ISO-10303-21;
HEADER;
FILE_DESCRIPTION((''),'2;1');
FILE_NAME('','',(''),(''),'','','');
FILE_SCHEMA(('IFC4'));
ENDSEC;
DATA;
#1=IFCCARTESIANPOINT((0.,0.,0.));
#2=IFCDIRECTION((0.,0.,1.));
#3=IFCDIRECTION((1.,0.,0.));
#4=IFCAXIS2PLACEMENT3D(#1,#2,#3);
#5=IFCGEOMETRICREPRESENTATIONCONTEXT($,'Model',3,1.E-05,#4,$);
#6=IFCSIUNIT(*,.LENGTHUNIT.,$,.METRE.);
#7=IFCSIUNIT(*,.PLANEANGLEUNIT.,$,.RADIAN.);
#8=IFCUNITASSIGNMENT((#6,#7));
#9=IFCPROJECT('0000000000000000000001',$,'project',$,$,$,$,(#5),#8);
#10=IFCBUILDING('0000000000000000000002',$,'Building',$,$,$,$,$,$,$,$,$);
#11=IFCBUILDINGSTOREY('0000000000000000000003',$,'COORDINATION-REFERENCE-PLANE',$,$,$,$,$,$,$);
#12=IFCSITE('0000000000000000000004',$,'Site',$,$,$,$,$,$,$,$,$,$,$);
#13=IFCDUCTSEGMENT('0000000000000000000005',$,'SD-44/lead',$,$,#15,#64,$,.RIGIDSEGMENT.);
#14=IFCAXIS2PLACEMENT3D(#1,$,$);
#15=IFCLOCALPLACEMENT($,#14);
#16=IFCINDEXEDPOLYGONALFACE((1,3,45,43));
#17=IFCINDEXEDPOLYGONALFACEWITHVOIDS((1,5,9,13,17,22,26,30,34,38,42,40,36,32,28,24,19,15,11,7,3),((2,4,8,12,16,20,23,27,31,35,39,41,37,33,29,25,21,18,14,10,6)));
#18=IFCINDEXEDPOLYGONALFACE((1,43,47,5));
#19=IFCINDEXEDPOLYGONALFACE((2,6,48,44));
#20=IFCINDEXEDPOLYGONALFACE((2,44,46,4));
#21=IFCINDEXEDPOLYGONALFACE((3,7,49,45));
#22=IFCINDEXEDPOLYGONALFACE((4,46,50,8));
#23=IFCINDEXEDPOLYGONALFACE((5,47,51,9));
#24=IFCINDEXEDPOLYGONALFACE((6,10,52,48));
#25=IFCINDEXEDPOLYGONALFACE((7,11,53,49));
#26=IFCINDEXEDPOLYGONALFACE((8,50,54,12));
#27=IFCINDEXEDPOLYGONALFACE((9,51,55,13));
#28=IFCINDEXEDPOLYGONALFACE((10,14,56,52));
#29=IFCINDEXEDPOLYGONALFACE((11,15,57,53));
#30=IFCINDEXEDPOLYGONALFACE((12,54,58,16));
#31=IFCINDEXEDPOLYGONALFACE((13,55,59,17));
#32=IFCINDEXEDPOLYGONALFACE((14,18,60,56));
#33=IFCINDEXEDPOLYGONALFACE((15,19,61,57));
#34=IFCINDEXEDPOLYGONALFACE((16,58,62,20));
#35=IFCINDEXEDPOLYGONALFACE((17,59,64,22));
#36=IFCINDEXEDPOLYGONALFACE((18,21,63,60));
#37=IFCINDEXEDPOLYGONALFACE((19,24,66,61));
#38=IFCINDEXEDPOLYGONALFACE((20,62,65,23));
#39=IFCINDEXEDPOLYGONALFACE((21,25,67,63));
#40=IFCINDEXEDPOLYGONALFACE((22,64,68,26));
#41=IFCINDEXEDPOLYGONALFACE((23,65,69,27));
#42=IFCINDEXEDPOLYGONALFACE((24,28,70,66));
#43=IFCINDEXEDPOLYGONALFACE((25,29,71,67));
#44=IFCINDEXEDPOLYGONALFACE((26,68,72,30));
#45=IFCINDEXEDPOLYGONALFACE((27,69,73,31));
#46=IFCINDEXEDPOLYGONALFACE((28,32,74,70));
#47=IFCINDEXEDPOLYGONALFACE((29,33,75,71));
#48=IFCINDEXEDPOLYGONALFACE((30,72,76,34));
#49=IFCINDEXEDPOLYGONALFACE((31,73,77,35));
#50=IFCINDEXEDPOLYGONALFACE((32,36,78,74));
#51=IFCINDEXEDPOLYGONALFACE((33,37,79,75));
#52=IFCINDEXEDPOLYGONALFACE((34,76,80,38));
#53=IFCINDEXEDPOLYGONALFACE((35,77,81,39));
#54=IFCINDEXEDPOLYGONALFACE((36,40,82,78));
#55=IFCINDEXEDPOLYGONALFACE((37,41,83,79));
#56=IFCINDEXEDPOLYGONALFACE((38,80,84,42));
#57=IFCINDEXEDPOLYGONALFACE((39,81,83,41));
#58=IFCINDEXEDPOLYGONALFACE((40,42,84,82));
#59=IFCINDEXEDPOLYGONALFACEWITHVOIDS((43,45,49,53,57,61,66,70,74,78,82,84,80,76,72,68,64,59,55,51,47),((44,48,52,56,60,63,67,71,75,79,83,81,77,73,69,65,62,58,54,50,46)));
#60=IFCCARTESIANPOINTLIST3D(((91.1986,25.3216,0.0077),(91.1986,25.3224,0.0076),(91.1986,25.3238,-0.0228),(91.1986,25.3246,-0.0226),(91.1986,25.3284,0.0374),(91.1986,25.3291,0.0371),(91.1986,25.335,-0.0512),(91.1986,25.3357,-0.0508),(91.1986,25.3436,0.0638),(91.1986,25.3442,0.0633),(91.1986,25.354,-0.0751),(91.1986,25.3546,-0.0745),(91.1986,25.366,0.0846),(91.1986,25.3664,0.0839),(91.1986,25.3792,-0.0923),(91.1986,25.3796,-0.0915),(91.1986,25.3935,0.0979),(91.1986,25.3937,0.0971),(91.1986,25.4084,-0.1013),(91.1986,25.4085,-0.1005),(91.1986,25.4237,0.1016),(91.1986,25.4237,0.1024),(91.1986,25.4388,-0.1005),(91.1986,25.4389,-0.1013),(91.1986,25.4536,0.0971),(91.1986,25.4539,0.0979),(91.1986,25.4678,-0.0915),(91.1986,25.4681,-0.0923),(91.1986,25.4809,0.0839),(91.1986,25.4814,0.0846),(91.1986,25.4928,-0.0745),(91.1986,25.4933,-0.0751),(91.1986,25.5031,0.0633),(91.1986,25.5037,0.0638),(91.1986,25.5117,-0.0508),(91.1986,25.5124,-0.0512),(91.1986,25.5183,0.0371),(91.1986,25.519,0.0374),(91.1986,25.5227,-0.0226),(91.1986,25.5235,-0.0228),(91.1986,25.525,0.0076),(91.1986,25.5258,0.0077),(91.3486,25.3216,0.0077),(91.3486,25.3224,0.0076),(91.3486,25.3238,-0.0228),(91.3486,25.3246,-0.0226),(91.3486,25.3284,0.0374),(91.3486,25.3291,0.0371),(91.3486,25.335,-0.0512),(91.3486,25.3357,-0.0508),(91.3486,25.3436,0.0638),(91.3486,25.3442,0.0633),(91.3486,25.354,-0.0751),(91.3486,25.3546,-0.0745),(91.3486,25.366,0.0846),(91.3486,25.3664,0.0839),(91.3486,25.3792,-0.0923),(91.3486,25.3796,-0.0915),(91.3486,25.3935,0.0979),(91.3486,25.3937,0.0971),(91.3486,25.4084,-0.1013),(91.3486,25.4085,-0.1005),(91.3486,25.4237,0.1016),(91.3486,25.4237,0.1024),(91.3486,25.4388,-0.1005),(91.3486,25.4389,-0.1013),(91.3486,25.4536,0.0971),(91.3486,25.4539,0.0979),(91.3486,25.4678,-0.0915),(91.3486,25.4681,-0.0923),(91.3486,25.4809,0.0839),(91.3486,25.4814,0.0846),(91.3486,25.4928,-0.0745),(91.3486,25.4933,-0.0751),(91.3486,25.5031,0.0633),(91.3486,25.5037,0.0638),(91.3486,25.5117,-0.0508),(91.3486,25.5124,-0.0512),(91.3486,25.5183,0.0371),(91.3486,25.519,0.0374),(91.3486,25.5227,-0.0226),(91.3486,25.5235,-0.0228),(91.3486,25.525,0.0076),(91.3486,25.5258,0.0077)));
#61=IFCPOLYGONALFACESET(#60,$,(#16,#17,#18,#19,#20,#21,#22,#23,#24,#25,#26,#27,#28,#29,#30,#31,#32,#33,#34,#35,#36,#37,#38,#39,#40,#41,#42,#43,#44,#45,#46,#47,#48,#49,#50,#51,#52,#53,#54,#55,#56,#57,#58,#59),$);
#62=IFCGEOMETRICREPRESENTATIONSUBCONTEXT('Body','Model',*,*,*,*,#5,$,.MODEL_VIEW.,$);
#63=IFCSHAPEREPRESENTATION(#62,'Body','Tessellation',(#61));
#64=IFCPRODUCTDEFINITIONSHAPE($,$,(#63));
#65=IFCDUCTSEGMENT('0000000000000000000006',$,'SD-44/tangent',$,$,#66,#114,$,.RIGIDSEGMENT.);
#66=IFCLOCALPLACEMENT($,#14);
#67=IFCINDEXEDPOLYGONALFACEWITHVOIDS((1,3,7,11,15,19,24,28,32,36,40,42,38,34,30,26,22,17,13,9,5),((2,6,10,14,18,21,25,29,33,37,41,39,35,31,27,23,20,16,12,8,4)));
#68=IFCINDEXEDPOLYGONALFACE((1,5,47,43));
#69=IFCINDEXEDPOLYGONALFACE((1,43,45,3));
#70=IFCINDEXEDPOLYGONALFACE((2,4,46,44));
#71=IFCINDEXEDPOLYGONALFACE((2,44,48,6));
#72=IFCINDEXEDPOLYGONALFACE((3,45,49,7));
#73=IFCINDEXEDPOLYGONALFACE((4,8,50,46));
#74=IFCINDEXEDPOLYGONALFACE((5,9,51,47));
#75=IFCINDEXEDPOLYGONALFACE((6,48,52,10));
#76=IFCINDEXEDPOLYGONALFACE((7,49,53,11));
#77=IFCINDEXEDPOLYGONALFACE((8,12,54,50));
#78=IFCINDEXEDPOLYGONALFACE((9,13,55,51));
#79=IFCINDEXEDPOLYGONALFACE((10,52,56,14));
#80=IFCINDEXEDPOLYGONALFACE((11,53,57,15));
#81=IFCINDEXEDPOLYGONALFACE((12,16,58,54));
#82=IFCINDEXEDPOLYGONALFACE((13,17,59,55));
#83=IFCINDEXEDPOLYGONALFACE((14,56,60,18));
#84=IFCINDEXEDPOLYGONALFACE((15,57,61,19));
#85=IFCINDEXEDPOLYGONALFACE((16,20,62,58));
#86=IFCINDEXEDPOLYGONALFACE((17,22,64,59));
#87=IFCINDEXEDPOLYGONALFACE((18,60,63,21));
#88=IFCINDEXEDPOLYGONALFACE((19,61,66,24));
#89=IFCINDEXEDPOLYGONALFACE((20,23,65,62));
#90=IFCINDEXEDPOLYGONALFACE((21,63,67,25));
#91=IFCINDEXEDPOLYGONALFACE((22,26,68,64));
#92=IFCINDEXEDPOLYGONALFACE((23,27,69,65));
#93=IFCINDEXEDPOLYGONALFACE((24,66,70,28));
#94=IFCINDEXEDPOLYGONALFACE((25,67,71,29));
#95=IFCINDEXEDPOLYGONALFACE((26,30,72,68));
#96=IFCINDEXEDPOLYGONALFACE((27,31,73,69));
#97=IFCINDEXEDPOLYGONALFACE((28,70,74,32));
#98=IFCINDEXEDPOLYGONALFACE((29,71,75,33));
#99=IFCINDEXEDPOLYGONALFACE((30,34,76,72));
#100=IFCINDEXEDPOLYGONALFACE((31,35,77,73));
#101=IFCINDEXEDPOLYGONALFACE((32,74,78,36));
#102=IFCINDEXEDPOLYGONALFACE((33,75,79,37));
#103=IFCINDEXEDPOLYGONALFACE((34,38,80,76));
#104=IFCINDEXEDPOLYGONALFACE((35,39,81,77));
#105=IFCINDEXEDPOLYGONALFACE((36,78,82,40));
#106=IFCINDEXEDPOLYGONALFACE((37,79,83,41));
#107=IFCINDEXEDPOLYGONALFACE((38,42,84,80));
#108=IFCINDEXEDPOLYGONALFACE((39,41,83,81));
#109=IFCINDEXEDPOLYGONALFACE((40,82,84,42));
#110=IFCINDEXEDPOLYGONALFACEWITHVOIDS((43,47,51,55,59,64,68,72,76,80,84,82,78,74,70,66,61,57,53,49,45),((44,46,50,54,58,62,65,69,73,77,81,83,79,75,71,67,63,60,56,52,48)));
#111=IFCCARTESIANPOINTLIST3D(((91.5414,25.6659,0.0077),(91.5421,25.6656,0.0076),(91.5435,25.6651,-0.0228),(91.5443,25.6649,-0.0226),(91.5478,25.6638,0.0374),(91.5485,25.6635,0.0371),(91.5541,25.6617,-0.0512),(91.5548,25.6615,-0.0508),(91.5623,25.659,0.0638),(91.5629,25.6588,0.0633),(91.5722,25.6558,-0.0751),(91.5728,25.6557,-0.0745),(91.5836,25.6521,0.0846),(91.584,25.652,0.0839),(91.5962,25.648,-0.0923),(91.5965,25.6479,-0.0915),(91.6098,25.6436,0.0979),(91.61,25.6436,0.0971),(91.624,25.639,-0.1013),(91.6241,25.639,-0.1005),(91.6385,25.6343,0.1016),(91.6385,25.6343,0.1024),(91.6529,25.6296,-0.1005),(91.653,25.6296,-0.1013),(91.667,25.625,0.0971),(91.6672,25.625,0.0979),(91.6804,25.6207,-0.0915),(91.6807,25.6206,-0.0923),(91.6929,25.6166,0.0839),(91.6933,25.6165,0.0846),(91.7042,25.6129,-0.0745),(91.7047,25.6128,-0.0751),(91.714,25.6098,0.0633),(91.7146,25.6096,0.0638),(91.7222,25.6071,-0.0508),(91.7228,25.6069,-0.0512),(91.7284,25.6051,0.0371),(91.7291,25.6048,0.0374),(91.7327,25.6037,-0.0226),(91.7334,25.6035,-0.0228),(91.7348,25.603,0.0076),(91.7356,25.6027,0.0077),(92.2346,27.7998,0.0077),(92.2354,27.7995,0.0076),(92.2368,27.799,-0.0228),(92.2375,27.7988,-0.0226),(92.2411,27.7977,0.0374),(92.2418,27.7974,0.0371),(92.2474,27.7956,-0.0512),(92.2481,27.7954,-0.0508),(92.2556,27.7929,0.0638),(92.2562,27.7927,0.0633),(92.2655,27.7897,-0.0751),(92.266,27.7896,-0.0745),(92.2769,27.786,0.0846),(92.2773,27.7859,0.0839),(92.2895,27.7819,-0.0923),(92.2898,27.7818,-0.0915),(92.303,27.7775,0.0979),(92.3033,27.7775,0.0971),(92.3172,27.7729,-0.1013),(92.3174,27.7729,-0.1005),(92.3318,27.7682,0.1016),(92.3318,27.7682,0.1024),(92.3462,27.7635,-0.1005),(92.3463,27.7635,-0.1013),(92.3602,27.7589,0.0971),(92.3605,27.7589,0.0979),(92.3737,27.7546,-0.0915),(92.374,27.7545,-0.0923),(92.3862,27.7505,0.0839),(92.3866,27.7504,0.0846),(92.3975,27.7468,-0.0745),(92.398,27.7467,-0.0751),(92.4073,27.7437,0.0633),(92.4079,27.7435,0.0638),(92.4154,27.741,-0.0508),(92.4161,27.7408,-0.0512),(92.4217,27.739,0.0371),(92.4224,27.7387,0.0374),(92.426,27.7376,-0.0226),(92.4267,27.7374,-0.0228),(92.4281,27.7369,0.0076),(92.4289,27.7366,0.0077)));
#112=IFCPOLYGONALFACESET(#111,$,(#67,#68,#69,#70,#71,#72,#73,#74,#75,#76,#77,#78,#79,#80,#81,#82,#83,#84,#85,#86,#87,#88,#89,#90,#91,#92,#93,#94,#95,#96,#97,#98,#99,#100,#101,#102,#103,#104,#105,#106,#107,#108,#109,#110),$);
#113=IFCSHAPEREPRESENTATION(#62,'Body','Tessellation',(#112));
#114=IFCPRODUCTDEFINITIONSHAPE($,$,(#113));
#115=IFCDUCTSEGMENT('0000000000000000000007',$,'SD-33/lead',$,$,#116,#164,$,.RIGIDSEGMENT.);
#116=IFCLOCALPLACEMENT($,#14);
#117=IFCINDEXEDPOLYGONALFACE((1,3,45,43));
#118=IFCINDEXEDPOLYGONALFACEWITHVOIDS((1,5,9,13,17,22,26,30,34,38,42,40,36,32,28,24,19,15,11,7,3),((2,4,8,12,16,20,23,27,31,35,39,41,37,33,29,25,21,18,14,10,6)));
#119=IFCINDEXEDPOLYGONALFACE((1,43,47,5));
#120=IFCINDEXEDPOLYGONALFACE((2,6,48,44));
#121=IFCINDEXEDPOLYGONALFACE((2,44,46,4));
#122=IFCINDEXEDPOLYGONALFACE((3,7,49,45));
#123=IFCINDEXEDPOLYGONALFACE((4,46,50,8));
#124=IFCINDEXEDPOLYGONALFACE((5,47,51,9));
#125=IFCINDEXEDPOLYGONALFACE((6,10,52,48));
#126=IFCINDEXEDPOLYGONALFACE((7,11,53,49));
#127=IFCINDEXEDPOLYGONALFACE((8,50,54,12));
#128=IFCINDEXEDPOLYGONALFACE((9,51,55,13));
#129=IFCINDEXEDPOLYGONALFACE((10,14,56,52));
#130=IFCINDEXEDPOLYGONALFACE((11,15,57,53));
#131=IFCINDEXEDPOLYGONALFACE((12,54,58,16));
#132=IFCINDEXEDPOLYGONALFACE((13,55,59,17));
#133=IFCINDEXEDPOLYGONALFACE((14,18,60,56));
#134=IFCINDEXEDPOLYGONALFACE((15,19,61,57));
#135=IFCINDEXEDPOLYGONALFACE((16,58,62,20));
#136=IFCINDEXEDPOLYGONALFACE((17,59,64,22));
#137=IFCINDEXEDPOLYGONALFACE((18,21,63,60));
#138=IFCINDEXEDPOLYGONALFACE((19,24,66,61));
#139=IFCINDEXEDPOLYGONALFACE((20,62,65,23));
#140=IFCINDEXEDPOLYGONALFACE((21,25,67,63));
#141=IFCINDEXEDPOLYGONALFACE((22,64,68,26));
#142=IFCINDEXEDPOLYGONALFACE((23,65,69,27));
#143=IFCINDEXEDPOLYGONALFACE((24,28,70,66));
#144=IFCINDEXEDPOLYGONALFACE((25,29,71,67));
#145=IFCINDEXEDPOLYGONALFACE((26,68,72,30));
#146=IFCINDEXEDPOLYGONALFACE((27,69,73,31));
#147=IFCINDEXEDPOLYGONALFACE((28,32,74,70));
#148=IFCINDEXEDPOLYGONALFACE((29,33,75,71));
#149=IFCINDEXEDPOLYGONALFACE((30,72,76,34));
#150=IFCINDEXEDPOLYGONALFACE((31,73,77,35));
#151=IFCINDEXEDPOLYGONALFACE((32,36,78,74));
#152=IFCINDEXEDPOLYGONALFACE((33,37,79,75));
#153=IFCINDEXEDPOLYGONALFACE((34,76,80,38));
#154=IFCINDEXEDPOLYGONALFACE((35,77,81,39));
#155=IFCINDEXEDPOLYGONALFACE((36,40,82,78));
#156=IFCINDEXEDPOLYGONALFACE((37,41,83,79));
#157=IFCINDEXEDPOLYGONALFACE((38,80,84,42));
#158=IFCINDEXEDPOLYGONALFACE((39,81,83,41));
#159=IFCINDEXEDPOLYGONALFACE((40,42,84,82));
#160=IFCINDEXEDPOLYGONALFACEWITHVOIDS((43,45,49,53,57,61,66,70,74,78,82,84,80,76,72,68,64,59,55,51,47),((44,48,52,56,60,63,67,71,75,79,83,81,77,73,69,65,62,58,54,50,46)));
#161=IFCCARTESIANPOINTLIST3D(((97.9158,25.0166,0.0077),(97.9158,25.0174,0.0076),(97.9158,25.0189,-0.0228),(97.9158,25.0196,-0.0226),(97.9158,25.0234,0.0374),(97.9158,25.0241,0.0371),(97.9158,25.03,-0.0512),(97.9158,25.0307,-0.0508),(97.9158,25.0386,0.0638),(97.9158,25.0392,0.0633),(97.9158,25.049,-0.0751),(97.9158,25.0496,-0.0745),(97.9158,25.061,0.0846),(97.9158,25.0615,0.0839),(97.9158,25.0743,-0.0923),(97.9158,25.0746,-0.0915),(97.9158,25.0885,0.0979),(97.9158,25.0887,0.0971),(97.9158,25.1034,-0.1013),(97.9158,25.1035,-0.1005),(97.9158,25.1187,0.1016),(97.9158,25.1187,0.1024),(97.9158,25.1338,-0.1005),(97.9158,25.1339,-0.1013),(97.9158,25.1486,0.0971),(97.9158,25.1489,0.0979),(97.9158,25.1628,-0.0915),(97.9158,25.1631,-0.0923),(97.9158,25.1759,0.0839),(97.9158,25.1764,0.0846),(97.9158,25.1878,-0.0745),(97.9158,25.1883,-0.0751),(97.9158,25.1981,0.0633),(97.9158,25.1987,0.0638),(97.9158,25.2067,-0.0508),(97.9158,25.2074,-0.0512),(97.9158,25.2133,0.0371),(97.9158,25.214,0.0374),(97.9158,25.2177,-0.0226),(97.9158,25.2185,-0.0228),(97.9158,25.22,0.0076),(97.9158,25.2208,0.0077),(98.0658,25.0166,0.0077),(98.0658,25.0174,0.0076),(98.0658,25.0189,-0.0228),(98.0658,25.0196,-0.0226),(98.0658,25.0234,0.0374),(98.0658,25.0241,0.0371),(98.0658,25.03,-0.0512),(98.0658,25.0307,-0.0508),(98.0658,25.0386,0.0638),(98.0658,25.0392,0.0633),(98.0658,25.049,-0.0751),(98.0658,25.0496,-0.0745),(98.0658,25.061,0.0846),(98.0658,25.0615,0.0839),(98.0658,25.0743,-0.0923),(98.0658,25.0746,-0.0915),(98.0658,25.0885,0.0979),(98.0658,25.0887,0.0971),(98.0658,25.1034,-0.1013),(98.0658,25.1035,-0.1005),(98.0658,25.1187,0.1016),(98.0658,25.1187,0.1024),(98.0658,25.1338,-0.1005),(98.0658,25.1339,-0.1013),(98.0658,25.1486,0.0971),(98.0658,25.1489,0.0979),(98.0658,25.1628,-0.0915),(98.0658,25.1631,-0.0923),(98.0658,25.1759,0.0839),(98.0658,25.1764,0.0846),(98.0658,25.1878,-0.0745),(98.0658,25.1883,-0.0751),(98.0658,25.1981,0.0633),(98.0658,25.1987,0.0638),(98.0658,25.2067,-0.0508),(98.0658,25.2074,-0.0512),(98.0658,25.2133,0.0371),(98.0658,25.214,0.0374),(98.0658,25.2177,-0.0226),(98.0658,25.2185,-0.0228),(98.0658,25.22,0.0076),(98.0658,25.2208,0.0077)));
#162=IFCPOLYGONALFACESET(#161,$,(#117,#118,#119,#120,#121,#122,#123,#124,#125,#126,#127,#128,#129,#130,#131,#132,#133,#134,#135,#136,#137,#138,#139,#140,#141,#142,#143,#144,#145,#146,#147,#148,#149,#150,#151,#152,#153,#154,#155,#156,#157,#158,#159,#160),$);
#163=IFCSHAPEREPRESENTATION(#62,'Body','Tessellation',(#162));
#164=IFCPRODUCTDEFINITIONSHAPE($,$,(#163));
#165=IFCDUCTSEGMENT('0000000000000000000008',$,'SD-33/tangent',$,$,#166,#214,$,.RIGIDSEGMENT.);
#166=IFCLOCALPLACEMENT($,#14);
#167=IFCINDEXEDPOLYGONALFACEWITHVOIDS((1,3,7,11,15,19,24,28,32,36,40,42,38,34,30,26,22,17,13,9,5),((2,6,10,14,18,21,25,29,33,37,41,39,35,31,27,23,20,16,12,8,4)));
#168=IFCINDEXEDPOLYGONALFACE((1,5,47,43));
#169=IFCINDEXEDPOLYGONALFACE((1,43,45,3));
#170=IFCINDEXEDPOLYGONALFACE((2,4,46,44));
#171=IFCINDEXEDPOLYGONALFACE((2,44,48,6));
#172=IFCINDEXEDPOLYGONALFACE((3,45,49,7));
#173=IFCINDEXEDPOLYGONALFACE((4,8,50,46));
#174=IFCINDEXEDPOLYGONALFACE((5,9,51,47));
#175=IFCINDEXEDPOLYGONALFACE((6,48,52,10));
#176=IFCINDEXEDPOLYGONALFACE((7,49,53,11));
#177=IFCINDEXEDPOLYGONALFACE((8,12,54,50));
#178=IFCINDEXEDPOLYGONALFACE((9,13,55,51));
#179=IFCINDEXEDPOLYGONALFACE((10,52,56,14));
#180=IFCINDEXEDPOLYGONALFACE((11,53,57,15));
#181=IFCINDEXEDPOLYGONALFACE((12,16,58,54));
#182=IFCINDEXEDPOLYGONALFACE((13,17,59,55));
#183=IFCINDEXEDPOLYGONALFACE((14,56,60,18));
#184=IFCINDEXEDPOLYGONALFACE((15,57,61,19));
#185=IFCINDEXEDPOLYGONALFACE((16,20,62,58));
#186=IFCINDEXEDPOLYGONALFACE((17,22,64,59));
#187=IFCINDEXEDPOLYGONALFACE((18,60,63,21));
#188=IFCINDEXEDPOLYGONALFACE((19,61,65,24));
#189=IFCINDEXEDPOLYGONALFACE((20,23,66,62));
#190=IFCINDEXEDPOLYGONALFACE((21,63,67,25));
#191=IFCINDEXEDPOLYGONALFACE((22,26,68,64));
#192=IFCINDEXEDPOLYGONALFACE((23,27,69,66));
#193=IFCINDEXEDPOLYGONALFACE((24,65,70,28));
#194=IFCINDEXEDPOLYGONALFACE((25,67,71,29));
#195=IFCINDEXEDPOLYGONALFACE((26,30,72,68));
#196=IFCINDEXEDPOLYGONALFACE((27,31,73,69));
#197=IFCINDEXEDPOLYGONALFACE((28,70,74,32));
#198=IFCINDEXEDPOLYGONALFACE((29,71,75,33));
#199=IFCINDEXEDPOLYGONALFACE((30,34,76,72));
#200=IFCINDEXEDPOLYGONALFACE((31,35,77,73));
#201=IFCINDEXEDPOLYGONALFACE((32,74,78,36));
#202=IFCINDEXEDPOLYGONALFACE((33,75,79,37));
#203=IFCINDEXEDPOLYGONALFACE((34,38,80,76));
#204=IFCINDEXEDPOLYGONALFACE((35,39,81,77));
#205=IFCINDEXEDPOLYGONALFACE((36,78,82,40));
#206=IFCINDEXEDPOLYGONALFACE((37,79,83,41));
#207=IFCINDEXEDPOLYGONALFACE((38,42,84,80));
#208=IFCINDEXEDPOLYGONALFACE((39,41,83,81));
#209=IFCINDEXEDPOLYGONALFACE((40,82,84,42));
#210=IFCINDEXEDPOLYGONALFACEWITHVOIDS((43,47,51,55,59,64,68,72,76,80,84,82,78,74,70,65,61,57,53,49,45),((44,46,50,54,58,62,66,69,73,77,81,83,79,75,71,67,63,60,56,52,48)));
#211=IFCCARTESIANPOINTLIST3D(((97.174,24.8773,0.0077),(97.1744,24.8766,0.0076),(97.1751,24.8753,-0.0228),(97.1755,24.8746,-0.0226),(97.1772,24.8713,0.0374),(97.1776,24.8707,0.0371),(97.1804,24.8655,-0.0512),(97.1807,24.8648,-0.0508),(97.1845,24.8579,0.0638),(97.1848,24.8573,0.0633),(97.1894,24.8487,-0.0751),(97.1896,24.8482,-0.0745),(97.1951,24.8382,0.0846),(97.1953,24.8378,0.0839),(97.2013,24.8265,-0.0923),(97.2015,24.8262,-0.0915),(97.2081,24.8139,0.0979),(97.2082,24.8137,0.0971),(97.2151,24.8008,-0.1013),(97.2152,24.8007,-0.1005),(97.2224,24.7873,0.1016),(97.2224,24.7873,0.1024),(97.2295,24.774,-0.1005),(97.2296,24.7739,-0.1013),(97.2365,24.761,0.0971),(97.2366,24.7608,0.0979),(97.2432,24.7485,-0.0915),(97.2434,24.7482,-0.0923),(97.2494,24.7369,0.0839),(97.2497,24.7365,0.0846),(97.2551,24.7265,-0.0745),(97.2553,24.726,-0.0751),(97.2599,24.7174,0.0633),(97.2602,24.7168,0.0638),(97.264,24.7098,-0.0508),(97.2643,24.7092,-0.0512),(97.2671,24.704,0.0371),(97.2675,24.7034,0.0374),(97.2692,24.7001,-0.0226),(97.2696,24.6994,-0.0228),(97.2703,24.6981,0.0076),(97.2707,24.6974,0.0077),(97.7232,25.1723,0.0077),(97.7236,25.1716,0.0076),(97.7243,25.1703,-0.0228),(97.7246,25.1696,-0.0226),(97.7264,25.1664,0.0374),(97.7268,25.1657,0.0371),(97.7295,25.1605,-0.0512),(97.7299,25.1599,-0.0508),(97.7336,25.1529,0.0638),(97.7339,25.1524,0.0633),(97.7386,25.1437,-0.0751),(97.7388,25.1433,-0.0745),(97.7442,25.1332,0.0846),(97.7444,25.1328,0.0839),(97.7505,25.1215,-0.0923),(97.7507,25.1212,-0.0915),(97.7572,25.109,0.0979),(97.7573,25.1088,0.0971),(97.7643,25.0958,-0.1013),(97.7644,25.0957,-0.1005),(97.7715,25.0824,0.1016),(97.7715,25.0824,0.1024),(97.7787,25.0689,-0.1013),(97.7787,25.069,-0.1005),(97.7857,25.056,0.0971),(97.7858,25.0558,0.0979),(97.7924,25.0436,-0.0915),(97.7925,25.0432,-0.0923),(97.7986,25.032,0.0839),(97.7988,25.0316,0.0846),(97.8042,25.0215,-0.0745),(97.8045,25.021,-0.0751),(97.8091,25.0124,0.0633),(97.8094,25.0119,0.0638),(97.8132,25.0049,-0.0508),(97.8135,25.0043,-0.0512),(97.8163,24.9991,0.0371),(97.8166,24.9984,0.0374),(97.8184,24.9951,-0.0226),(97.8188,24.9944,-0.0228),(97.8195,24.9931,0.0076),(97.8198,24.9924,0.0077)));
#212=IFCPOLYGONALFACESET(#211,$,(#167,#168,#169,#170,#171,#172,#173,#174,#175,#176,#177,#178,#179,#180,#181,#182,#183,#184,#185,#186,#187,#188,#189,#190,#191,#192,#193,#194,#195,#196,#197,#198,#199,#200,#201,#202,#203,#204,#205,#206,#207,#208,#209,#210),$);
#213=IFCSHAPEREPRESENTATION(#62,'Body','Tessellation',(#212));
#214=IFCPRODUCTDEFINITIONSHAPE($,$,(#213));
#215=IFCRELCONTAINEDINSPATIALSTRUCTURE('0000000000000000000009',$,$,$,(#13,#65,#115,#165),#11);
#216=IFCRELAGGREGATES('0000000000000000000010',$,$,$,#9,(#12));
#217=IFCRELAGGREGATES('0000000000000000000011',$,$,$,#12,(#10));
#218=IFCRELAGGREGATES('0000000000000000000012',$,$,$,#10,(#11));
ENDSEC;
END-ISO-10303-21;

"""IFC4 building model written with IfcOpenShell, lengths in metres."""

from ifc_helpers import new_model, si_unit, frame, origin_with_axes, place, context, subcontext, project, spatial, hollow_circle, extrude, element, save


model = new_model("IFC4")

# Units and contexts
model_context = context("Model", 3, precision=1e-05, world=origin_with_axes())
body_context_1 = subcontext(model_context, "Body", "Model", "MODEL_VIEW")
ifc_project = project(units=[si_unit("LENGTHUNIT", "METRE"), si_unit("PLANEANGLEUNIT", "RADIAN")], contexts=[model_context])

# Site, building, storey
site = spatial("IfcSite", under=ifc_project, Name="Site")
building = spatial("IfcBuilding", under=site, Name="Building")
storey = spatial("IfcBuildingStorey", under=building, Name="COORDINATION-REFERENCE-PLANE")

# Duct segment
for number, where, z_axis, x_axis, name in (
    (1, (91.1986, 25.4237, 0.0), (1.0, 0.0, 0.0), (0.0, 0.0, 1.0), "SD-44/lead"),
):
    element("IfcDuctSegment", number, at=place(None, frame(where, z_axis=z_axis, x_axis=x_axis)), inside=storey, Name=name, PredefinedType="RIGIDSEGMENT", context=body_context_1, shape_type="SweptSolid", body=[
        extrude(hollow_circle(Radius=0.1024, WallThickness=0.0008), origin_with_axes(), (0.0, 0.0, 1.0), 0.15),
    ])

# Duct segments
duct_segment_1_placement = place(None, frame((91.6385, 25.6343, 0.0), z_axis=(0.30899, 0.951065, 0.0), x_axis=(0.0, 0.0, 1.0)))
element("IfcDuctSegment", 2, at=duct_segment_1_placement, inside=storey, Name="SD-44/tangent", PredefinedType="RIGIDSEGMENT", context=body_context_1, shape_type="SweptSolid", body=[
    extrude(hollow_circle(Radius=0.1024, WallThickness=0.0008), origin_with_axes(), (0.0, 0.0, 1.0), 2.2437),
])
duct_segment_2_placement = place(None, frame((98.0658, 25.1187, 0.0), z_axis=(-1.0, 0.0, 0.0), x_axis=(0.0, 0.0, 1.0)))
element("IfcDuctSegment", 3, at=duct_segment_2_placement, inside=storey, Name="SD-33/lead", PredefinedType="RIGIDSEGMENT", context=body_context_1, shape_type="SweptSolid", body=[
    extrude(hollow_circle(Radius=0.1024, WallThickness=0.0008), origin_with_axes(), (0.0, 0.0, 1.0), 0.15),
])

# Duct segment
duct_segment_3_placement = place(None, frame((97.7715, 25.0824, 0.0), z_axis=(-0.880912, -0.473279, 0.0), x_axis=(0.0, 0.0, 1.0)))
element("IfcDuctSegment", 4, at=duct_segment_3_placement, inside=storey, Name="SD-33/tangent", PredefinedType="RIGIDSEGMENT", context=body_context_1, shape_type="SweptSolid", body=[
    extrude(hollow_circle(Radius=0.1024, WallThickness=0.0008), origin_with_axes(), (0.0, 0.0, 1.0), 0.6234),
])

save(model, "model.ifc")
